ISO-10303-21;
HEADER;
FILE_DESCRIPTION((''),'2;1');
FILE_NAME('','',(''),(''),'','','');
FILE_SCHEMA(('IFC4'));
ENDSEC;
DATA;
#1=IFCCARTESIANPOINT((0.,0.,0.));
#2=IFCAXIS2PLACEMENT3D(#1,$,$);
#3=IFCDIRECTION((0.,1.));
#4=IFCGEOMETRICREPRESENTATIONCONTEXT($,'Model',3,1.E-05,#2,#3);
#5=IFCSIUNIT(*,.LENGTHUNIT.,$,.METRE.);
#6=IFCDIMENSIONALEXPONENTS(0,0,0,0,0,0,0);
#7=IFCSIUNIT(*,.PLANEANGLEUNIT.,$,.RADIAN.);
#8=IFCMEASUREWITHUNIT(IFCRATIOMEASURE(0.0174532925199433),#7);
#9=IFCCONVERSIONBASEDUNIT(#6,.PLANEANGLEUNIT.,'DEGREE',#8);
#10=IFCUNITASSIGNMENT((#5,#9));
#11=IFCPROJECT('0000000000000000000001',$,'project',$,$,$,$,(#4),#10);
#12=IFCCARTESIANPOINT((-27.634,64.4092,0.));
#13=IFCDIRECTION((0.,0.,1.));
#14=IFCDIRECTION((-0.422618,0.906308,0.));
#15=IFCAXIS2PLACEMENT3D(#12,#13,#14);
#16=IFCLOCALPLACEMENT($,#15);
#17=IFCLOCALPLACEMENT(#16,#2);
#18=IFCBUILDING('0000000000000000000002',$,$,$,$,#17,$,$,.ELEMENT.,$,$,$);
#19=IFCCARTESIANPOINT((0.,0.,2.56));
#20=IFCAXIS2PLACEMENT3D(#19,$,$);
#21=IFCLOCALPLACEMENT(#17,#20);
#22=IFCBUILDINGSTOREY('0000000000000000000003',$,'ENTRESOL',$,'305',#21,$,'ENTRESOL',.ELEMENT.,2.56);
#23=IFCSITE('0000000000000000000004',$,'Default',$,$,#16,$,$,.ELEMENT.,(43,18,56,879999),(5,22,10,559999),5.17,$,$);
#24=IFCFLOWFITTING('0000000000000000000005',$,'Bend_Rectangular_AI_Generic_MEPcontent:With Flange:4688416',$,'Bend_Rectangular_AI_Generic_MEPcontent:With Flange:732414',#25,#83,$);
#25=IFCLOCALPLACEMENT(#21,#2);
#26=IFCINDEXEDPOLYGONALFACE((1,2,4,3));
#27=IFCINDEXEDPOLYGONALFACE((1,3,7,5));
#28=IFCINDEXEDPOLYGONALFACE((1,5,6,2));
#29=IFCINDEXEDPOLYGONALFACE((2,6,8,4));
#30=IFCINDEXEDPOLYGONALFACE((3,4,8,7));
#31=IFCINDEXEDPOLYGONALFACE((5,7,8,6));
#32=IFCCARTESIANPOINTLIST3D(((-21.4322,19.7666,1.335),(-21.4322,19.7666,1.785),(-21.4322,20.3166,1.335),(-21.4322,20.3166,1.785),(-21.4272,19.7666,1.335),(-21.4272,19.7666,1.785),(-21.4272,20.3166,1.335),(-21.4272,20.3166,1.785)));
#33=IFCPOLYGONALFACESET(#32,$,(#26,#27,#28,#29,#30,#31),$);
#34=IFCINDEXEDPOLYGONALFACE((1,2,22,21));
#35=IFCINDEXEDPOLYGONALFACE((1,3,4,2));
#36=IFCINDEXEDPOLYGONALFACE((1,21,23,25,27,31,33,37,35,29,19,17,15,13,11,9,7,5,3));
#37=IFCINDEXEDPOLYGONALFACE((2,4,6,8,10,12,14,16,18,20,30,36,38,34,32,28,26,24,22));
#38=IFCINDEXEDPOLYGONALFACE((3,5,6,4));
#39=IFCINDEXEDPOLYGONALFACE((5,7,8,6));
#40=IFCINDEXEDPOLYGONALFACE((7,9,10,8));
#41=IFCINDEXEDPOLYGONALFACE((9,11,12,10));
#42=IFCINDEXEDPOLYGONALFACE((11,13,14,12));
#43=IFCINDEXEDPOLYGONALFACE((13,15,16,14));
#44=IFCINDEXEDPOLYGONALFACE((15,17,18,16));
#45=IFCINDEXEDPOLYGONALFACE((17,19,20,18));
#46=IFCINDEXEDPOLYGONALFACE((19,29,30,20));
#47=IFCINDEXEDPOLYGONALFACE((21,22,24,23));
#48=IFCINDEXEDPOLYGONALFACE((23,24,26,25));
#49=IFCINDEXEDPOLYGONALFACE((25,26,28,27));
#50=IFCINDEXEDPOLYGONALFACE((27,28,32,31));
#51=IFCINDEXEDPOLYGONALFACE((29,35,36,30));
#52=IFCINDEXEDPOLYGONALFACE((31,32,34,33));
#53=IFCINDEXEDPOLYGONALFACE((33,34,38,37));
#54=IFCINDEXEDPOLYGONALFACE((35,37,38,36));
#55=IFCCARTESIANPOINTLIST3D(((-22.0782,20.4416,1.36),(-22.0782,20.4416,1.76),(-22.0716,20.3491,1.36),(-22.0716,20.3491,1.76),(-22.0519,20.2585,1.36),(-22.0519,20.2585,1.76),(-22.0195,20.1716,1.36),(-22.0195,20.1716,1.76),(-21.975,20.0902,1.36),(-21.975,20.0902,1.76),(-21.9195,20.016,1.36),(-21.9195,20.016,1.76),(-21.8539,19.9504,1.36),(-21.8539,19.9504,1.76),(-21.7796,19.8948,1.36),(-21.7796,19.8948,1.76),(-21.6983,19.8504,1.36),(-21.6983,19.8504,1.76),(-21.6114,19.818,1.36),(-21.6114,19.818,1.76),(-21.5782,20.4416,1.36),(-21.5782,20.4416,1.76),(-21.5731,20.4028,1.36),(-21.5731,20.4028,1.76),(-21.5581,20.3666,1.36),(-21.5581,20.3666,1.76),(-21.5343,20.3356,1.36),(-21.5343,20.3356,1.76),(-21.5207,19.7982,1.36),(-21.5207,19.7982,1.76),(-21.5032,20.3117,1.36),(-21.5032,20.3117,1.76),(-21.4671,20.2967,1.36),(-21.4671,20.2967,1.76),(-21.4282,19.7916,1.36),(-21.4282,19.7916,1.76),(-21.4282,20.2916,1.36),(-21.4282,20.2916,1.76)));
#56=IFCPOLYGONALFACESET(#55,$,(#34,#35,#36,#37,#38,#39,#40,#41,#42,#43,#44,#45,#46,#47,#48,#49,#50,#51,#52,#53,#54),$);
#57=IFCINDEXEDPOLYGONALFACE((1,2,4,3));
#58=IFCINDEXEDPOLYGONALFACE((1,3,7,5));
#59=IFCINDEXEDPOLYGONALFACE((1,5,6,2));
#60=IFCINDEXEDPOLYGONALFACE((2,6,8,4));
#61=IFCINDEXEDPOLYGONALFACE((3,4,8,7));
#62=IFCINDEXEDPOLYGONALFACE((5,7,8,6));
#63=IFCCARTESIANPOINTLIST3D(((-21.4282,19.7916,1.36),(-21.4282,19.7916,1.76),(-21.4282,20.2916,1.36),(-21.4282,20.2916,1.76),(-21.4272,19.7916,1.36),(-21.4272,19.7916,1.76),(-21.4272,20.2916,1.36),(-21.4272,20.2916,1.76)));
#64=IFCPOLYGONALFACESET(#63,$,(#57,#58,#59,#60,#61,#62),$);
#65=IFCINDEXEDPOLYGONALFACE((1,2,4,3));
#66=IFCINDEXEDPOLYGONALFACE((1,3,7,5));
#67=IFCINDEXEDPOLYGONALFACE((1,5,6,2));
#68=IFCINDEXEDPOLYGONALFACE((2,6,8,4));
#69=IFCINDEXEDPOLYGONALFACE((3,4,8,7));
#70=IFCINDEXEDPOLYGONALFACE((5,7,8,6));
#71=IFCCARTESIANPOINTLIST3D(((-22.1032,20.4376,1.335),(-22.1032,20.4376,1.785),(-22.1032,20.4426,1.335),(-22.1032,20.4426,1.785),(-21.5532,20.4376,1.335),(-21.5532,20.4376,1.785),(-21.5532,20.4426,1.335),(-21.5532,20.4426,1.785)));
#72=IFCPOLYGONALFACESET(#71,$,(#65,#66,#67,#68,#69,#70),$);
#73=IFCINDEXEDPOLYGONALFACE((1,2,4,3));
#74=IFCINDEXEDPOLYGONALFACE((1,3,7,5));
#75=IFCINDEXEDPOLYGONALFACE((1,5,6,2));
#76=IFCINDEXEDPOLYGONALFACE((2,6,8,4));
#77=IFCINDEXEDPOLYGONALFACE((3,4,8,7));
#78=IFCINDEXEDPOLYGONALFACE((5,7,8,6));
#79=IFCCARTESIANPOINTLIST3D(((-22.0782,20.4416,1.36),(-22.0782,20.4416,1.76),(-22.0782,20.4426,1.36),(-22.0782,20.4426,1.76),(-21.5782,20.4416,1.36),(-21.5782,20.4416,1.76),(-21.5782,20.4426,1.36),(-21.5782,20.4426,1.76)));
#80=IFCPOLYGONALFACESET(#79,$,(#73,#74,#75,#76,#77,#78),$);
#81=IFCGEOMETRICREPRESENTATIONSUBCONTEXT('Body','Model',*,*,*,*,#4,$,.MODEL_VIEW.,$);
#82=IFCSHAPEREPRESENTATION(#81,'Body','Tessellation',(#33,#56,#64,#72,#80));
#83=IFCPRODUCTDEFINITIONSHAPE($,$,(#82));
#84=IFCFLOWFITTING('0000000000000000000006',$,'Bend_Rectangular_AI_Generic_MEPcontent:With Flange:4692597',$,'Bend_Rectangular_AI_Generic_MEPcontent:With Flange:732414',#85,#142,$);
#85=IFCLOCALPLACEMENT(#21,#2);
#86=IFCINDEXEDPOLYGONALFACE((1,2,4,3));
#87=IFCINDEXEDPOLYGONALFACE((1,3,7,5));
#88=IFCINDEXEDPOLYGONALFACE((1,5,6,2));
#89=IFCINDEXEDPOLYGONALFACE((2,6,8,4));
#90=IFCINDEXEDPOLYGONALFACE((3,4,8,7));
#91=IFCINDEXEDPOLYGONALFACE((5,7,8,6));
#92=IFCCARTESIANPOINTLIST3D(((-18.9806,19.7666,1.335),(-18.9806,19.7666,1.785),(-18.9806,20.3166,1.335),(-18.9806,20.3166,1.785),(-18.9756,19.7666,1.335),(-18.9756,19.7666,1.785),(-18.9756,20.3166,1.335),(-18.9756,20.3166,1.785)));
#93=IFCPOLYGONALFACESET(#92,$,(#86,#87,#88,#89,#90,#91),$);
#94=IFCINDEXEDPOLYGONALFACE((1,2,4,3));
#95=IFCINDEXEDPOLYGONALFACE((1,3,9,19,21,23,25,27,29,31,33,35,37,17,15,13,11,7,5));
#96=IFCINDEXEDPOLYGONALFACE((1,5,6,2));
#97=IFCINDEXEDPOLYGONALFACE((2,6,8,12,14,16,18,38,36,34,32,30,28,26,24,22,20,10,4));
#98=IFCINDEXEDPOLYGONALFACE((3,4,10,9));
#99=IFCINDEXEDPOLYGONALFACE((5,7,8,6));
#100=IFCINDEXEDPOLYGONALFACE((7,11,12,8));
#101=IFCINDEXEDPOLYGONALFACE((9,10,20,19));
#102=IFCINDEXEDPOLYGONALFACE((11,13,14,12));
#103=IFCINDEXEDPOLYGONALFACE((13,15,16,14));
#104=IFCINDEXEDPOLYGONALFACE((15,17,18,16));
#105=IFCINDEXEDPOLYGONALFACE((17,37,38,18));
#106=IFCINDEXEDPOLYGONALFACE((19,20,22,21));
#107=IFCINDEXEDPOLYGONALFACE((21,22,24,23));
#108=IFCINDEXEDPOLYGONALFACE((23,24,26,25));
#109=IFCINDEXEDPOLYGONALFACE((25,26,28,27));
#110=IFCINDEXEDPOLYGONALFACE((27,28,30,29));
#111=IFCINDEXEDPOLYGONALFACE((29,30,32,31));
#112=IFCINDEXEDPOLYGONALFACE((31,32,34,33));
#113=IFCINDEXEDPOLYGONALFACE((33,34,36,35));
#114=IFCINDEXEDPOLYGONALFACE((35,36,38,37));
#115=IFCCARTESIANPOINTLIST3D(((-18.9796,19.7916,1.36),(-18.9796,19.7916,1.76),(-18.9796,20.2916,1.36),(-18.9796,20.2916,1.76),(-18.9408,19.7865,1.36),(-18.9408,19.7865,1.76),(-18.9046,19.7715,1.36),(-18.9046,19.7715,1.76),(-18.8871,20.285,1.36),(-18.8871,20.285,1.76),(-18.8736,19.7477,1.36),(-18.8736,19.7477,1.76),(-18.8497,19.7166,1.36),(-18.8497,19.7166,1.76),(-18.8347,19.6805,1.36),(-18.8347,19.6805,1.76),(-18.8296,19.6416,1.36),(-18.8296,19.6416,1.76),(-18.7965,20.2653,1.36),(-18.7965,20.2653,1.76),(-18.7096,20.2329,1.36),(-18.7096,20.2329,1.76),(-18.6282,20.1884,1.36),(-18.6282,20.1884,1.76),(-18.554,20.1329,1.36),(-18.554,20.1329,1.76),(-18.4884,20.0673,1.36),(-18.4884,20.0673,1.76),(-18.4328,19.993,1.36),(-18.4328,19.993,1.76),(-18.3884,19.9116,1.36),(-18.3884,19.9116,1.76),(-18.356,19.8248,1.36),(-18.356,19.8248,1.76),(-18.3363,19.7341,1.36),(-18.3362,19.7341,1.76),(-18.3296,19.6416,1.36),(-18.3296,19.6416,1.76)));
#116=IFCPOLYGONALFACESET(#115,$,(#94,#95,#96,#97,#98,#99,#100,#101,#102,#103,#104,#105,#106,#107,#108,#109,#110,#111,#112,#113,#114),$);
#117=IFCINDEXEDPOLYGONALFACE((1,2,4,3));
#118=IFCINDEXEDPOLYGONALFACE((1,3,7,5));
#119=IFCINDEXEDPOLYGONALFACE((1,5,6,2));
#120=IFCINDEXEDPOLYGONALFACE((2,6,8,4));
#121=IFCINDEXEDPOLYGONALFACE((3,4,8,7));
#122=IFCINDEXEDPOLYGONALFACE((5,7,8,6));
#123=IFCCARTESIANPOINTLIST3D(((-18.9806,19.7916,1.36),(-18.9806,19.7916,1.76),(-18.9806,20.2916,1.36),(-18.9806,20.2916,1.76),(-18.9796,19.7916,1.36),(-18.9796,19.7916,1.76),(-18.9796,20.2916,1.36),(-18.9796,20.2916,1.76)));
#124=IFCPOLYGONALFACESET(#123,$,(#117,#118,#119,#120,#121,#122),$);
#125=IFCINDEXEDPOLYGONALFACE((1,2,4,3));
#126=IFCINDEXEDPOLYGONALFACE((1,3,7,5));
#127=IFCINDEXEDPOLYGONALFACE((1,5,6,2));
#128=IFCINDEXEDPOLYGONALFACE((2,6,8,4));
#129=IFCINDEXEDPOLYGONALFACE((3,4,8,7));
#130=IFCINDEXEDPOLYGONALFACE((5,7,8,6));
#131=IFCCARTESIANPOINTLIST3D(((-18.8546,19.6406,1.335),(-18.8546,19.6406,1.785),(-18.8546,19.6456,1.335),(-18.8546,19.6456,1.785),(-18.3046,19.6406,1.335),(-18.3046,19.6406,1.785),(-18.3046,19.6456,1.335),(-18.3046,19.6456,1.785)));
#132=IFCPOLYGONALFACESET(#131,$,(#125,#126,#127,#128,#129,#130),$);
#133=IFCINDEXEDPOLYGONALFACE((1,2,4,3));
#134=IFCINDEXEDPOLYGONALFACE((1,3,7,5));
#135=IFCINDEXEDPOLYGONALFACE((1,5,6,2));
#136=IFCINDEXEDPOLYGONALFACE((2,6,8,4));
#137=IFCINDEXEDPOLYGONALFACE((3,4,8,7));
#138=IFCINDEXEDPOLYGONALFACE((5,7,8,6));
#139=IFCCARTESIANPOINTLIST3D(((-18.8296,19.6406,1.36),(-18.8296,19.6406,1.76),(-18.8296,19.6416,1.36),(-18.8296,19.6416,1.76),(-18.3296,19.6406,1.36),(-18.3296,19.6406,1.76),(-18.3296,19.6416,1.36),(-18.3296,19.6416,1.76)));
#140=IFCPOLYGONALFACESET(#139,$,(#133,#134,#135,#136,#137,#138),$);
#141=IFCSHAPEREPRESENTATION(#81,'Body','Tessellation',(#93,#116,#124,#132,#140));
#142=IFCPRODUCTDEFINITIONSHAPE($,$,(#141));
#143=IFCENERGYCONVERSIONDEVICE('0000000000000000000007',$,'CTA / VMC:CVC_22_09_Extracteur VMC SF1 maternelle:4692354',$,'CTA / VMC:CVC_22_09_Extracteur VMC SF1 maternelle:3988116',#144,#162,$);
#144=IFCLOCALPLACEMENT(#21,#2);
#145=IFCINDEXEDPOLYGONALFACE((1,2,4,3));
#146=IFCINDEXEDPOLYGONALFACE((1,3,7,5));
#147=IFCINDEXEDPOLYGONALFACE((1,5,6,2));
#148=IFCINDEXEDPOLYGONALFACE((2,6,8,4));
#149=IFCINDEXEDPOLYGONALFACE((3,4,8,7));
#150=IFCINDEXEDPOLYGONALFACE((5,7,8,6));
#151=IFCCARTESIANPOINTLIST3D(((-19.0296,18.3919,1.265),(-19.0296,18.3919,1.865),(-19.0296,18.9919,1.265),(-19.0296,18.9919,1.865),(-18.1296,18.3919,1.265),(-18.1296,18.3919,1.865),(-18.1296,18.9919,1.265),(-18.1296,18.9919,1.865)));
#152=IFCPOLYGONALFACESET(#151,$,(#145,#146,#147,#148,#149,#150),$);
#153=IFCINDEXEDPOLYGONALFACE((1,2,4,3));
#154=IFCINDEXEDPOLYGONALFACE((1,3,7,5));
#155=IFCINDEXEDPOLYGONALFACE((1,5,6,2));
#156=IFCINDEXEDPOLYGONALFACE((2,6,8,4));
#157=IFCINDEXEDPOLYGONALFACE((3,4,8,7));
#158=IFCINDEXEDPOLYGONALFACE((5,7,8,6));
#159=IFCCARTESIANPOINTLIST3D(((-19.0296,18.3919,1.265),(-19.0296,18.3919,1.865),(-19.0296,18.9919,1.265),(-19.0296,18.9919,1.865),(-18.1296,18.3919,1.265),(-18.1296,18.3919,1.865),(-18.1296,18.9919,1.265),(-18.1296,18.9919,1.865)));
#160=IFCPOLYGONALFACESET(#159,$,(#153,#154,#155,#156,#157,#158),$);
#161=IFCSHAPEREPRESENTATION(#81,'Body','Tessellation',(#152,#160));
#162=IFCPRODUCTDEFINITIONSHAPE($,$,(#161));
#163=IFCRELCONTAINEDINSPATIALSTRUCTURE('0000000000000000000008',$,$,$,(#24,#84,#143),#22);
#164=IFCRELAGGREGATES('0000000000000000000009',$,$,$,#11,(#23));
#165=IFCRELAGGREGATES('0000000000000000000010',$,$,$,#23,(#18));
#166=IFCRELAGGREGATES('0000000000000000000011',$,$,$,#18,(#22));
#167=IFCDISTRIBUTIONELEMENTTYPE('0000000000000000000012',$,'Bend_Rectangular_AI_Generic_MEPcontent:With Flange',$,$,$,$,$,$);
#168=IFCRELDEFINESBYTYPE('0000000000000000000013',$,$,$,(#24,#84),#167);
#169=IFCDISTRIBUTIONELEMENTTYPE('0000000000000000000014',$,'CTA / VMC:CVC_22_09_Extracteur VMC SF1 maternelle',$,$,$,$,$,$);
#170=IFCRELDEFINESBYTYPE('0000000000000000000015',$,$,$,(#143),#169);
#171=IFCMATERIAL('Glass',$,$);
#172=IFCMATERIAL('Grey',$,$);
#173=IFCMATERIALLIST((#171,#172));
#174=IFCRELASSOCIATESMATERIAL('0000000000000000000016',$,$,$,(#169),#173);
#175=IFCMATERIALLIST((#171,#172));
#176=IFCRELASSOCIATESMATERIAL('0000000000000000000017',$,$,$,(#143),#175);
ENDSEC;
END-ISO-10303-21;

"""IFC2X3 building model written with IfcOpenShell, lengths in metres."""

from ifc_helpers import new_model, entity, si_unit, converted_unit, direction, frame, frame_2d, origin, origin_2d_with_axis, place, context, subcontext, project, spatial, polyline, circle_curve, parameter, trimmed, segment, composite_curve, rectangle, outline, extrude, source, transform, mapped, material, material_list, type_object, type_shapes, element, save


model = new_model("IFC2X3")

# Units and contexts
model_context = context("Model", 3, precision=1e-05, world=origin(), true_north=direction((0.0, 1.0)))
body_context = subcontext(model_context, "Body", "Model", "MODEL_VIEW")
ifc_project = project(units=[si_unit("LENGTHUNIT", "METRE"), converted_unit("PLANEANGLEUNIT", "DEGREE", entity("IfcRatioMeasure", 0.0174532925199433), si_unit("PLANEANGLEUNIT", "RADIAN"), dimensions=[0, 0, 0, 0, 0, 0, 0])], contexts=[model_context])

# Site, building, storey
site_placement = place(None, frame((-27.634, 64.4092, 0.0), z_axis=(0.0, 0.0, 1.0), x_axis=(-0.422618, 0.906308, 0.0)))
site = spatial("IfcSite", under=ifc_project, at=site_placement, Name="Default", CompositionType="ELEMENT", RefLatitude=(43, 18, 56, 879999), RefLongitude=(5, 22, 10, 559999), RefElevation=5.17)
building_placement = place(site_placement, origin())
building = spatial("IfcBuilding", under=site, at=building_placement, CompositionType="ELEMENT")
storey_placement = place(building_placement, frame((0.0, 0.0, 2.56)))
storey = spatial("IfcBuildingStorey", under=building, at=storey_placement, Name="ENTRESOL", ObjectType="305", LongName="ENTRESOL", CompositionType="ELEMENT", Elevation=2.56)

# Flow fittings
distribution_element_type_1 = type_object("IfcDistributionElementType", Name="Bend_Rectangular_AI_Generic_MEPcontent:With Flange")
shared_shape_1 = source(origin(), body_context, "Body", "SweptSolid", [
    extrude(rectangle(XDim=0.005, YDim=0.55, at=origin_2d_with_axis()), frame((0.0, 0.3985, -0.225), z_axis=(0.0, 0.0, 1.0), x_axis=(0.0, -1.0, 0.0)), (0.0, 0.0, 1.0), 0.45),
    extrude(outline(composite_curve([segment(trimmed(circle_curve(frame_2d((-0.2, 0.2), x_axis=(1.0, 0.0)), 0.65), [parameter(270.0)], [parameter(0.0)], True, "PARAMETER"), True, "CONTINUOUS"), segment(polyline([(0.45, 0.2), (-0.05, 0.2)]), True, "CONTINUOUS"), segment(trimmed(circle_curve(frame_2d((-0.2, 0.2), x_axis=(1.0, 0.0)), 0.15), [parameter(270.0)], [parameter(0.0)], True, "PARAMETER"), False, "CONTINUOUS"), segment(polyline([(-0.2, 0.05), (-0.2, -0.45)]), True, "CONTINUOUS")], self_intersect=False)), frame((-0.2, 0.2, -0.2)), (0.0, 0.0, 1.0), 0.4),
    extrude(rectangle(XDim=0.001, YDim=0.5, at=origin_2d_with_axis()), frame((0.0, 0.4005, -0.2), z_axis=(0.0, 0.0, 1.0), x_axis=(0.0, 1.0, 0.0)), (0.0, 0.0, 1.0), 0.4),
    extrude(rectangle(XDim=0.005, YDim=0.55, at=frame_2d((0.0, 0.0), x_axis=(1.0, 0.0))), frame((-0.3985, 0.0, -0.225)), (0.0, 0.0, 1.0), 0.45),
    extrude(rectangle(XDim=0.001, YDim=0.5, at=frame_2d((0.0, 0.0), x_axis=(1.0, 0.0))), frame((-0.4005, 0.0, -0.2), z_axis=(0.0, 0.0, 1.0), x_axis=(-1.0, 0.0, 0.0)), (0.0, 0.0, 1.0), 0.4),
])
type_shapes(distribution_element_type_1, [shared_shape_1])
for number, where, z_axis, x_axis, name in (
    (1, (-21.8282, 20.0416, 1.56), (0.000001, 0.0, 1.0), (0.0, -1.0, 0.0), "Bend_Rectangular_AI_Generic_MEPcontent:With Flange:4688416"),
    (2, (-18.5796, 20.0416, 1.56), (0.000001, 0.0, 1.0), (0.0, 1.0, 0.0), "Bend_Rectangular_AI_Generic_MEPcontent:With Flange:4692597"),
):
    element("IfcFlowFitting", number, at=place(storey_placement, frame(where, z_axis=z_axis, x_axis=x_axis)), inside=storey, type_object=distribution_element_type_1, Name=name, ObjectType="Bend_Rectangular_AI_Generic_MEPcontent:With Flange:732414", context=body_context, shape_type="MappedRepresentation", body=[
        mapped(shared_shape_1, transform((0.0, 0.0, 0.0), scale=1.0)),
    ])

# Energy conversion device
ifc_material_1 = material(Name="Glass")
ifc_material_2 = material(Name="Grey")
ifc_material_list_1 = material_list([ifc_material_1, ifc_material_2])
ifc_material_list_2 = material_list([ifc_material_1, ifc_material_2])
distribution_element_type_2 = type_object("IfcDistributionElementType", Name="CTA / VMC:CVC_22_09_Extracteur VMC SF1 maternelle", material=ifc_material_list_2)
shared_shape_2 = source(origin(), body_context, "Body", "SweptSolid", [
    extrude(rectangle(XDim=0.9, YDim=0.6, at=origin_2d_with_axis()), frame((0.0, 0.0, 0.0), z_axis=(0.0, 0.0, 1.0), x_axis=(-1.0, 0.0, 0.0)), (0.0, 0.0, 1.0), 0.6),
    extrude(rectangle(XDim=0.9, YDim=0.6, at=origin_2d_with_axis()), frame((0.0, 0.0, 0.0), z_axis=(0.0, 0.0, 1.0), x_axis=(-1.0, 0.0, 0.0)), (0.0, 0.0, 1.0), 0.6),
])
type_shapes(distribution_element_type_2, [shared_shape_2])
energy_conversion_device_placement = place(storey_placement, frame((-18.5796, 18.6919, 1.265), z_axis=(0.0, 0.0, 1.0), x_axis=(-1.0, 0.0, 0.0)))
element("IfcEnergyConversionDevice", 3, at=energy_conversion_device_placement, inside=storey, type_object=distribution_element_type_2, material=ifc_material_list_1, Name="CTA / VMC:CVC_22_09_Extracteur VMC SF1 maternelle:4692354", ObjectType="CTA / VMC:CVC_22_09_Extracteur VMC SF1 maternelle:3988116", context=body_context, shape_type="MappedRepresentation", body=[
    mapped(shared_shape_2, transform((0.0, 0.0, 0.0), scale=1.0)),
])

save(model, "model.ifc")
